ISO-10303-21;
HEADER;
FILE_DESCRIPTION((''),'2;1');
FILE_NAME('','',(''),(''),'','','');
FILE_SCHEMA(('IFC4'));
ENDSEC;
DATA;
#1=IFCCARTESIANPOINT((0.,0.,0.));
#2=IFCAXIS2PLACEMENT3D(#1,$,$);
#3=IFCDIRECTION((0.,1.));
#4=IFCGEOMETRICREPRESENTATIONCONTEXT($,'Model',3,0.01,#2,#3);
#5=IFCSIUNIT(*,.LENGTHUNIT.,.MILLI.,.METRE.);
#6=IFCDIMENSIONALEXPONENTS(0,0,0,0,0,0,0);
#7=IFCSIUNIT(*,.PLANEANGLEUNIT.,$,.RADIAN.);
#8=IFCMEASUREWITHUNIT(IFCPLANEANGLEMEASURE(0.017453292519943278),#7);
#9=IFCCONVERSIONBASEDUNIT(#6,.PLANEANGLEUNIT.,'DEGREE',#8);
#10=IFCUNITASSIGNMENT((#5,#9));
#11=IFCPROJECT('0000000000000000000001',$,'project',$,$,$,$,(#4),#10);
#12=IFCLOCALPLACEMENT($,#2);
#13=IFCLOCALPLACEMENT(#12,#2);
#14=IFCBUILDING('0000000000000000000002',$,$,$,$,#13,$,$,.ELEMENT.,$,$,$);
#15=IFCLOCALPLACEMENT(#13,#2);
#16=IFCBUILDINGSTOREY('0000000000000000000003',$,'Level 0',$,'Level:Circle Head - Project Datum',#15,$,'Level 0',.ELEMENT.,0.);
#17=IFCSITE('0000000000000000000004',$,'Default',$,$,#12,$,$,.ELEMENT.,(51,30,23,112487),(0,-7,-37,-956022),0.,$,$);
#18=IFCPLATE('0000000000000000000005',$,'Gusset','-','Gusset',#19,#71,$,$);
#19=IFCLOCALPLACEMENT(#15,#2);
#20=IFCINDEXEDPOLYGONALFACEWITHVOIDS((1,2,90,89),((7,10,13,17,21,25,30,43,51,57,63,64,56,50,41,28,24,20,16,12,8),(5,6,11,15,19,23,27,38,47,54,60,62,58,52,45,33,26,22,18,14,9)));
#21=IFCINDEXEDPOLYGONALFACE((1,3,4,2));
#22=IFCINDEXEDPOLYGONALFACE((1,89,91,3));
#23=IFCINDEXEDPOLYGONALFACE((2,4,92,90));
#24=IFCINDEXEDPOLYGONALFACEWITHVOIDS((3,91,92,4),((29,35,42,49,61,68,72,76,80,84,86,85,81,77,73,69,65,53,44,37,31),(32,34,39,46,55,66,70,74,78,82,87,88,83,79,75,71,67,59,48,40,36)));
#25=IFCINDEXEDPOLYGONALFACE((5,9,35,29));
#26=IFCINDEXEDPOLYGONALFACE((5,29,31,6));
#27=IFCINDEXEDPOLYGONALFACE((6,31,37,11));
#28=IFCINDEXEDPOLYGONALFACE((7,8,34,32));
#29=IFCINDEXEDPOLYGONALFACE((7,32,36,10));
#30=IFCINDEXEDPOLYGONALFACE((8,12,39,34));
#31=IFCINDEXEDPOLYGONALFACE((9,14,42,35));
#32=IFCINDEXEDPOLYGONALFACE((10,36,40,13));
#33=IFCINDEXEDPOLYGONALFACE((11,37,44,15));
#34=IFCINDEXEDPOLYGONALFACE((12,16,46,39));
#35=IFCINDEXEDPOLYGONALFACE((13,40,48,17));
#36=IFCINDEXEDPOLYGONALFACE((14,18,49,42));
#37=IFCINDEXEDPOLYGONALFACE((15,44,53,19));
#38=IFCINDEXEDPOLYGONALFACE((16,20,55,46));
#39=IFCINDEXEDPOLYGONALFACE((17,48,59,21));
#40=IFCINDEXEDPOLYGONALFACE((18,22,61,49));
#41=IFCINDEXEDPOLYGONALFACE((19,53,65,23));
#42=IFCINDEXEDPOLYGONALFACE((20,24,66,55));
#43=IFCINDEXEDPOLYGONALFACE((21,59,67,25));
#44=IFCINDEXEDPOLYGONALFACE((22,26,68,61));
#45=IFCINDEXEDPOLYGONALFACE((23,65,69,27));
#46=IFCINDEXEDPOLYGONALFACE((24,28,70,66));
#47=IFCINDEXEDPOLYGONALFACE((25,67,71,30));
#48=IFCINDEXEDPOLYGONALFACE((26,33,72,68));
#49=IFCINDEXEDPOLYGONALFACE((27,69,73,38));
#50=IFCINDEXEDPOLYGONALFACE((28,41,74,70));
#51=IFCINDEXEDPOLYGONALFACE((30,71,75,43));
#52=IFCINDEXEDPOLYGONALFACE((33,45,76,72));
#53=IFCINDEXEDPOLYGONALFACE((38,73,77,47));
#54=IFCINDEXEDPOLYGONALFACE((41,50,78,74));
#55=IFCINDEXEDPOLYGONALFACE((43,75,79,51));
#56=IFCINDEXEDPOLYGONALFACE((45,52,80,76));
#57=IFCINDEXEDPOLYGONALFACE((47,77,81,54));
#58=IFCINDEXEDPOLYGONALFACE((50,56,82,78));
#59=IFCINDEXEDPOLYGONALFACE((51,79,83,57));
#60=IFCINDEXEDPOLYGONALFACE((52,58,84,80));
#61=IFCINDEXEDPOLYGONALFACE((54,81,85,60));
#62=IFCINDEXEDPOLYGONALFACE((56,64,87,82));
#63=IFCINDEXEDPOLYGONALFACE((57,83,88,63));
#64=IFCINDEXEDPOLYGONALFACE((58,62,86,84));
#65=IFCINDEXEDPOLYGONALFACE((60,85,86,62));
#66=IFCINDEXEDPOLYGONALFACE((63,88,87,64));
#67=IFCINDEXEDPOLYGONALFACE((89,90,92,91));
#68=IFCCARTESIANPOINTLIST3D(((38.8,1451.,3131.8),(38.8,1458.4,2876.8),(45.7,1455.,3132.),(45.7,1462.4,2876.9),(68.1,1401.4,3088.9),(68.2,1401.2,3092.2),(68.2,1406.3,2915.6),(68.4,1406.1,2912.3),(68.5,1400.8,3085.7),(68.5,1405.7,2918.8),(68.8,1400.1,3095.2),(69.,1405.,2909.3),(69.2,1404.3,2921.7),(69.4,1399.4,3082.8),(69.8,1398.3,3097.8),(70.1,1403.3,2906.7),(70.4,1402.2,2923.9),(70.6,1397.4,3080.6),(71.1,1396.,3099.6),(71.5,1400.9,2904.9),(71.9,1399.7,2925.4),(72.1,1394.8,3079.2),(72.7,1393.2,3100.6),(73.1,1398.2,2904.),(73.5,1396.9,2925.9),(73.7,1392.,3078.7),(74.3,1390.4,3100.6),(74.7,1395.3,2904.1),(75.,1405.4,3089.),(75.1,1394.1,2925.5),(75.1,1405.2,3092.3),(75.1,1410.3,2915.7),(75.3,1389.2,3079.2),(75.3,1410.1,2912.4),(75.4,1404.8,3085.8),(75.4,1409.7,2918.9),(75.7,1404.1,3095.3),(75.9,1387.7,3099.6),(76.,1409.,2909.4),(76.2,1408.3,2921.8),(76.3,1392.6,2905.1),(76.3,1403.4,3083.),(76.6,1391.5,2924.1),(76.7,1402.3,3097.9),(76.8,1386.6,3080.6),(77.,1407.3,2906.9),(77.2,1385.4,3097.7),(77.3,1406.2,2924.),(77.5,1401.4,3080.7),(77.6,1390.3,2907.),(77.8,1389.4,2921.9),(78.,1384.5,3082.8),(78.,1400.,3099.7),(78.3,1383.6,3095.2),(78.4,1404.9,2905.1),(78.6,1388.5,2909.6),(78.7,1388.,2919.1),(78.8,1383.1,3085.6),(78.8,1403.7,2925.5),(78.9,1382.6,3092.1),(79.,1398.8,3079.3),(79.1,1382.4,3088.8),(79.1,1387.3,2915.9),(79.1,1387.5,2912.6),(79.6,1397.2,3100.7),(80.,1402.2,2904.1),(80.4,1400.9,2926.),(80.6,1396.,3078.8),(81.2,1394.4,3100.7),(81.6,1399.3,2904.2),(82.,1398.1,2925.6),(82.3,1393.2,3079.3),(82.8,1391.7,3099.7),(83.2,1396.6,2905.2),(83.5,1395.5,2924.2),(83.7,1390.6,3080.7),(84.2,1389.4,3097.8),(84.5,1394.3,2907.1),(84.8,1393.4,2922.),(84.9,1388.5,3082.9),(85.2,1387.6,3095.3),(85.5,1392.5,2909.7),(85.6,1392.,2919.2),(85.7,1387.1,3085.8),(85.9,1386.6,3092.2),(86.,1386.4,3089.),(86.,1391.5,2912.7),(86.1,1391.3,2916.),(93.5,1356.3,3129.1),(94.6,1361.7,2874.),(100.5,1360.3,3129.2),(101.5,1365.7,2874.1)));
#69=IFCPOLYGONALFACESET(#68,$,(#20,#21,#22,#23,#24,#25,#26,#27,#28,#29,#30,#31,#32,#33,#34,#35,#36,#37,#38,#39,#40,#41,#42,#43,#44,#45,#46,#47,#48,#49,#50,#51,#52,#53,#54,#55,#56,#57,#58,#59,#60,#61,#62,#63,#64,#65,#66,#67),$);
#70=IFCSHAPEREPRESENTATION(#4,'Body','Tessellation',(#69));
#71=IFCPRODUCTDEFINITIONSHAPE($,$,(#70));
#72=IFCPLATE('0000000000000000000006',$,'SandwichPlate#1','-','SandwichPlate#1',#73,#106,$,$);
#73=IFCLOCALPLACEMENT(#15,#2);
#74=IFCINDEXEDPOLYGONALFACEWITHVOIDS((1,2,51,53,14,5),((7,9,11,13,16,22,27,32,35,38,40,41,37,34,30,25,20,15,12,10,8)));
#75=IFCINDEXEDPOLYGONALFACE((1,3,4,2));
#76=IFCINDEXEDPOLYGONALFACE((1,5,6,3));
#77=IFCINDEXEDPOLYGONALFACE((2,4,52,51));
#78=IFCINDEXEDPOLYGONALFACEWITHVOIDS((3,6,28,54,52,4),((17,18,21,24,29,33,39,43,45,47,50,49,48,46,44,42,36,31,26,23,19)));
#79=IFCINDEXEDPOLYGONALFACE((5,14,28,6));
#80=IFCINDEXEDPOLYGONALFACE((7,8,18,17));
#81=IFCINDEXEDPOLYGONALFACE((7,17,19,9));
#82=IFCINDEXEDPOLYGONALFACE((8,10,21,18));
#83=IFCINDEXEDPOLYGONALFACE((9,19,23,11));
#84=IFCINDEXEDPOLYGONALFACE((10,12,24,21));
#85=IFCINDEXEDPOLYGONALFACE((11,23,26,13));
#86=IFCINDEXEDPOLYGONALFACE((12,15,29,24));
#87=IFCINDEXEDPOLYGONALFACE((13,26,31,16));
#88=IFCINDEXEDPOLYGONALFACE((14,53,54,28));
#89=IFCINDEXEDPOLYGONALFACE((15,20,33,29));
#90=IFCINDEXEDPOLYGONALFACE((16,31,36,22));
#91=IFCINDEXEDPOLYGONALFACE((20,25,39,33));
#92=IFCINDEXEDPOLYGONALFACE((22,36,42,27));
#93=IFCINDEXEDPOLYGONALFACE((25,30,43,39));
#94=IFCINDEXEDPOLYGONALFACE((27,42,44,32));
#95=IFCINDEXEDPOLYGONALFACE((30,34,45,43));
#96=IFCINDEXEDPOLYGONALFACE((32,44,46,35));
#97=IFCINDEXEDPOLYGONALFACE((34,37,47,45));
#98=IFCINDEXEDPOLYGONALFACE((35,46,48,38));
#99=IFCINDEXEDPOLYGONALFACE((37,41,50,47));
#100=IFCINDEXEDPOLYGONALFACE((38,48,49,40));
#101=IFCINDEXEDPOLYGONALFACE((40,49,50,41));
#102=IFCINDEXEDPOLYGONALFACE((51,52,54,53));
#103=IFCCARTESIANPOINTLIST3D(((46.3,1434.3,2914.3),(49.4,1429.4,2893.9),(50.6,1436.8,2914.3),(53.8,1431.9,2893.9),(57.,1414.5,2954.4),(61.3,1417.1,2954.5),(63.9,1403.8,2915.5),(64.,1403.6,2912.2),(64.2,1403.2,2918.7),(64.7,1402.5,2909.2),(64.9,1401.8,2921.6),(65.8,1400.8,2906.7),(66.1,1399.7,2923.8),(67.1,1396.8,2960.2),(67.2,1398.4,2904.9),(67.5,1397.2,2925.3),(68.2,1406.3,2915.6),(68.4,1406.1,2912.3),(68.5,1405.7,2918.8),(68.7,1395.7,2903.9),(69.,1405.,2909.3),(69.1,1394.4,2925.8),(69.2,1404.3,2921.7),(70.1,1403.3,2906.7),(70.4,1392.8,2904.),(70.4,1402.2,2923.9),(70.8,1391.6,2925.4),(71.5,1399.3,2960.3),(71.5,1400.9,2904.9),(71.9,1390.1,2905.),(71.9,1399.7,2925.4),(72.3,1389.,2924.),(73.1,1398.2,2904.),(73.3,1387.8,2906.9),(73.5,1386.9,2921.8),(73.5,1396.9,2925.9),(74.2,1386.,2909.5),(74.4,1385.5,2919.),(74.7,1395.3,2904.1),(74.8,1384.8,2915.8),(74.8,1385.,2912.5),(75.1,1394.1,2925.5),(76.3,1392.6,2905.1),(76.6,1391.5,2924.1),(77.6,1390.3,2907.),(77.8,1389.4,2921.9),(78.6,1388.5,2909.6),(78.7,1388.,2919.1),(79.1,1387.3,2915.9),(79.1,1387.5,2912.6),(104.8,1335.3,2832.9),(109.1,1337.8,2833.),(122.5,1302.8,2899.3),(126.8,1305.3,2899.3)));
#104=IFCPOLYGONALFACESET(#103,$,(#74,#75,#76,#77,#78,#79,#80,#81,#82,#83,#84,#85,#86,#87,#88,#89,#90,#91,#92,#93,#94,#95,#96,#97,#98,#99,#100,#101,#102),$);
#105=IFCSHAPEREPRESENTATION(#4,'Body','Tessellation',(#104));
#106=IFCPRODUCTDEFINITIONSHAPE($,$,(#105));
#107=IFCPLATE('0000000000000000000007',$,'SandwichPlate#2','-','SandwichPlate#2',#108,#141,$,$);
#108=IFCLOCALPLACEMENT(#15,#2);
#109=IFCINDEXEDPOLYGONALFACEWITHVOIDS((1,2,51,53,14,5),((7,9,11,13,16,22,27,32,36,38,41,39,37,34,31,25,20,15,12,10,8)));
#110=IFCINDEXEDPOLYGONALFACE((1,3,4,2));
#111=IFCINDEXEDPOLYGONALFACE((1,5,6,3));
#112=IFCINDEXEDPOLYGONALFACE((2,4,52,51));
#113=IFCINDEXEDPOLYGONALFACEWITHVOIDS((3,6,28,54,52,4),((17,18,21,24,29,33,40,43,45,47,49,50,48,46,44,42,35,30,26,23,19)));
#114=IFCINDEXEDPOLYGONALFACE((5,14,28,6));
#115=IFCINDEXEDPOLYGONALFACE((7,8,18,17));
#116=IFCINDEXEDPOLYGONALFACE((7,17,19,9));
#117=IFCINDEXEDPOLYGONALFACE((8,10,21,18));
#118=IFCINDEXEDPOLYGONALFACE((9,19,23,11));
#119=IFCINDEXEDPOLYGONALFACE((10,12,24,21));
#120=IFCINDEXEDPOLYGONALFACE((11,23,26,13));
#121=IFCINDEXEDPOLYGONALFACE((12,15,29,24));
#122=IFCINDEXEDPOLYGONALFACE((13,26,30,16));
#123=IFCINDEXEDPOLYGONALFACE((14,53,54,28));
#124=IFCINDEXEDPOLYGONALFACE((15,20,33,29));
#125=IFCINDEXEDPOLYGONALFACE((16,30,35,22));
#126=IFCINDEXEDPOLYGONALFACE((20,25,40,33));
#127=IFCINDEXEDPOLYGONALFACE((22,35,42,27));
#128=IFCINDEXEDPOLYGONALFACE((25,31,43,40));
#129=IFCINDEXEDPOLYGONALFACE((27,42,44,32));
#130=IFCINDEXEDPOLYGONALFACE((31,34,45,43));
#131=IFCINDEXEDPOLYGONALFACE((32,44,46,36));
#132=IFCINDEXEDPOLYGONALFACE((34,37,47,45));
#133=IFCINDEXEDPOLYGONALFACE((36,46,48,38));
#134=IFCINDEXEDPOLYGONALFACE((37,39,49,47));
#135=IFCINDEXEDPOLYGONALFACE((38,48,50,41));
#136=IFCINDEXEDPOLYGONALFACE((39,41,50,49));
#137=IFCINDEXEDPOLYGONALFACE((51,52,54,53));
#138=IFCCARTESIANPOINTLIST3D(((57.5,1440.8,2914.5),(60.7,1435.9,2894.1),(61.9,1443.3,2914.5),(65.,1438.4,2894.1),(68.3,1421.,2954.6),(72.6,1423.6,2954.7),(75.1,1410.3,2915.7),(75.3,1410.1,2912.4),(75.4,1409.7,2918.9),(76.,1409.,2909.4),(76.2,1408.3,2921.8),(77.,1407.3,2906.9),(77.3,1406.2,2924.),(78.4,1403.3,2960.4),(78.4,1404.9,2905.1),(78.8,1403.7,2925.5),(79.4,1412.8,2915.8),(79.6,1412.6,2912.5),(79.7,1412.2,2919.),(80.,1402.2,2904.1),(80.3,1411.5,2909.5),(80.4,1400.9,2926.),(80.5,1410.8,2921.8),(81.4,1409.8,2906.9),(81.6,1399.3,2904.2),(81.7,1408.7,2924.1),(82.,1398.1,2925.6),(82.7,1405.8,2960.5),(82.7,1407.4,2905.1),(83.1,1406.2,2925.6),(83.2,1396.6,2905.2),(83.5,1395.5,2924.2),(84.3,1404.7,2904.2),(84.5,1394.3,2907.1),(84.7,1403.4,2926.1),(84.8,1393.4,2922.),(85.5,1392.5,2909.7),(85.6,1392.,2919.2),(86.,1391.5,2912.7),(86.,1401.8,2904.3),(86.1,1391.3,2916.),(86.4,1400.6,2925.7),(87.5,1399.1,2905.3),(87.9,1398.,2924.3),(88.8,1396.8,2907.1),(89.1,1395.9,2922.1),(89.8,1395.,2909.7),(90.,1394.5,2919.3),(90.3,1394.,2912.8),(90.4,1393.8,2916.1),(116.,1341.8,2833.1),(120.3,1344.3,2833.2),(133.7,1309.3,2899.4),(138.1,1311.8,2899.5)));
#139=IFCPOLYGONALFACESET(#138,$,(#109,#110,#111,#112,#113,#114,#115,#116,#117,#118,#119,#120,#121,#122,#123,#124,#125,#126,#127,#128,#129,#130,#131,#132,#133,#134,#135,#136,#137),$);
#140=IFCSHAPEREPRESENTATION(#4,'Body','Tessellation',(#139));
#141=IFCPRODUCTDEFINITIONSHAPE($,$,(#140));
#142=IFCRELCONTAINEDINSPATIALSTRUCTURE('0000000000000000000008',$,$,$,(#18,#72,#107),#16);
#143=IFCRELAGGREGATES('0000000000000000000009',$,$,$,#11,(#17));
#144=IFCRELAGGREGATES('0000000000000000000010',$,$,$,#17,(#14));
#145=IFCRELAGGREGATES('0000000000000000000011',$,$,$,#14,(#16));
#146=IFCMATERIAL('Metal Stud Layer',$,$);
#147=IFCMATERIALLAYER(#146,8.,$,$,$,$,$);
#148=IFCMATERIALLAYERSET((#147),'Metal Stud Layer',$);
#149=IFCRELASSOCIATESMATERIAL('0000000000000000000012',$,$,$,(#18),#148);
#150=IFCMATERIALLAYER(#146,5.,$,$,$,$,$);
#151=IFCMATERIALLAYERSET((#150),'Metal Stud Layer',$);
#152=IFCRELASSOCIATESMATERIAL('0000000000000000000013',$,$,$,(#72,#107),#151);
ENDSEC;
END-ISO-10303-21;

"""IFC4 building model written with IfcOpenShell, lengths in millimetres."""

from ifc_helpers import new_model, entity, si_unit, converted_unit, direction, frame, origin, origin_with_axes, origin_2d_with_axis, place, context, project, spatial, polyline, circle, outline, extrude, material, layer, layer_set, element, save


model = new_model("IFC4")

# Units and contexts
model_context = context("Model", 3, precision=0.01, world=origin(), true_north=direction((0.0, 1.0)))
ifc_project = project(units=[si_unit("LENGTHUNIT", "METRE", prefix="MILLI"), converted_unit("PLANEANGLEUNIT", "DEGREE", entity("IfcPlaneAngleMeasure", 0.017453292519943278), si_unit("PLANEANGLEUNIT", "RADIAN"), dimensions=[0, 0, 0, 0, 0, 0, 0])], contexts=[model_context])

# Site, building, storey
site_placement = place(None, origin())
site = spatial("IfcSite", under=ifc_project, at=site_placement, Name="Default", CompositionType="ELEMENT", RefLatitude=(51, 30, 23, 112487), RefLongitude=(0, -7, -37, -956022), RefElevation=0.0)
building_placement = place(site_placement, origin())
building = spatial("IfcBuilding", under=site, at=building_placement, CompositionType="ELEMENT")
storey_placement = place(building_placement, origin())
storey = spatial("IfcBuildingStorey", under=building, at=storey_placement, Name="Level 0", ObjectType="Level:Circle Head - Project Datum", LongName="Level 0", CompositionType="ELEMENT", Elevation=0.0)

# Plates, openings
ifc_material_1 = material(Name="Metal Stud Layer")
ifc_layer_1 = layer(ifc_material_1, 8.0)
ifc_layer_set_1 = layer_set([ifc_layer_1], Name="Metal Stud Layer")
plate_1_placement = place(storey_placement, frame((46.7, 1453.3, 3131.9), z_axis=(-0.865935, -0.499948, -0.014432), x_axis=(0.0, 0.028855, -0.999584)))
plate_1 = element("IfcPlate", 1, at=plate_1_placement, inside=storey, material=ifc_layer_set_1, Name="Gusset", Description="-", ObjectType="Gusset", context=model_context, shape_type="SweptSolid", body=[
    extrude(outline(polyline([(0.0, -2.0), (255.1, -2.0), (255.1, 109.6), (0.0, 107.5), (0.0, -2.0)])), origin_with_axes(), (0.0, 0.0, 1.0), 8.0),
])
opening_1_placement = place(plate_1_placement, frame((40.4, 67.6, 8.5), z_axis=(0.0, 0.0, -1.0), x_axis=(-0.519479, 0.854483, 0.0)))
element("IfcOpeningElement", 2, at=opening_1_placement, cuts=plate_1, ObjectType="Opening", context=model_context, shape_type="SweptSolid", body=[
    extrude(circle(Radius=11.0, at=origin_2d_with_axis()), origin(), (0.0, 0.0, 1.0), 9.0),
])
opening_2_placement = place(plate_1_placement, frame((215.3, 67.8, 8.5), z_axis=(0.0, 0.0, -1.0), x_axis=(0.465705, 0.88494, 0.0)))
element("IfcOpeningElement", 3, at=opening_2_placement, cuts=plate_1, ObjectType="Opening", context=model_context, shape_type="SweptSolid", body=[
    extrude(circle(Radius=11.0, at=origin_2d_with_axis()), origin(), (0.0, 0.0, 1.0), 9.0),
])
ifc_layer_2 = layer(ifc_material_1, 5.0)
ifc_layer_set_2 = layer_set([ifc_layer_2], Name="Metal Stud Layer")
plate_2_placement = place(storey_placement, frame((42.8, 1440.7, 2901.2), z_axis=(0.865935, 0.499948, 0.014432), x_axis=(0.232925, -0.428638, 0.872935)))
plate_2 = element("IfcPlate", 4, at=plate_2_placement, inside=storey, material=ifc_layer_set_2, Name="SandwichPlate#1", Description="-", ObjectType="SandwichPlate#1", context=model_context, shape_type="SweptSolid", body=[
    extrude(outline(polyline([(0.0, 0.0), (76.0, 0.0), (76.0, 140.0), (0.0, 140.0), (0.0, 0.0)])), origin_with_axes(), (0.0, 0.0, 1.0), 5.0),
])
opening_3_placement = place(plate_2_placement, frame((0.0, 0.0, 0.0), z_axis=(0.0, 0.0, 1.0), x_axis=(1.0, 0.0, 0.0)))
element("IfcOpeningElement", 5, at=opening_3_placement, cuts=plate_2, ObjectType="Opening", context=model_context, shape_type="SweptSolid", body=[
    extrude(outline(polyline([(0.0, 0.0), (15.0, 0.0), (0.0, 15.0), (0.0, 0.0)])), origin(), (0.0, 0.0, 1.0), 5.0),
])
opening_4_placement = place(plate_2_placement, frame((0.0, 0.0, 0.0), z_axis=(0.0, 0.0, 1.0), x_axis=(1.0, 0.0, 0.0)))
element("IfcOpeningElement", 6, at=opening_4_placement, cuts=plate_2, ObjectType="Opening", context=model_context, shape_type="SweptSolid", body=[
    extrude(outline(polyline([(76.0, 0.0), (76.0, 15.0), (61.0, 0.0), (76.0, 0.0)])), origin(), (0.0, 0.0, 1.0), 5.0),
])
opening_5_placement = place(plate_2_placement, frame((38.0, 40.0, -0.5), z_axis=(0.0, 0.0, 1.0), x_axis=(0.0, 1.0, 0.0)))
element("IfcOpeningElement", 7, at=opening_5_placement, cuts=plate_2, ObjectType="Opening", context=model_context, shape_type="SweptSolid", body=[
    extrude(circle(Radius=11.0, at=origin_2d_with_axis()), origin(), (0.0, 0.0, 1.0), 6.0),
])
plate_3_placement = place(storey_placement, frame((54.1, 1447.2, 2901.4), z_axis=(0.865935, 0.499948, 0.014432), x_axis=(0.232925, -0.428638, 0.872935)))
plate_3 = element("IfcPlate", 8, at=plate_3_placement, inside=storey, material=ifc_layer_set_2, Name="SandwichPlate#2", Description="-", ObjectType="SandwichPlate#2", context=model_context, shape_type="SweptSolid", body=[
    extrude(outline(polyline([(0.0, 0.0), (76.0, 0.0), (76.0, 140.0), (0.0, 140.0), (0.0, 0.0)])), origin_with_axes(), (0.0, 0.0, 1.0), 5.0),
])
opening_6_placement = place(plate_3_placement, frame((0.0, 0.0, 0.0), z_axis=(0.0, 0.0, 1.0), x_axis=(1.0, 0.0, 0.0)))
element("IfcOpeningElement", 9, at=opening_6_placement, cuts=plate_3, ObjectType="Opening", context=model_context, shape_type="SweptSolid", body=[
    extrude(outline(polyline([(0.0, 0.0), (15.0, 0.0), (0.0, 15.0), (0.0, 0.0)])), origin(), (0.0, 0.0, 1.0), 5.0),
])
opening_7_placement = place(plate_3_placement, frame((0.0, 0.0, 0.0), z_axis=(0.0, 0.0, 1.0), x_axis=(1.0, 0.0, 0.0)))
element("IfcOpeningElement", 10, at=opening_7_placement, cuts=plate_3, ObjectType="Opening", context=model_context, shape_type="SweptSolid", body=[
    extrude(outline(polyline([(76.0, 0.0), (76.0, 15.0), (61.0, 0.0), (76.0, 0.0)])), origin(), (0.0, 0.0, 1.0), 5.0),
])
opening_8_placement = place(plate_3_placement, frame((38.0, 40.0, -0.5), z_axis=(0.0, 0.0, 1.0), x_axis=(0.0, 1.0, 0.0)))
element("IfcOpeningElement", 11, at=opening_8_placement, cuts=plate_3, ObjectType="Opening", context=model_context, shape_type="SweptSolid", body=[
    extrude(circle(Radius=11.0, at=origin_2d_with_axis()), origin(), (0.0, 0.0, 1.0), 6.0),
])

save(model, "model.ifc")
